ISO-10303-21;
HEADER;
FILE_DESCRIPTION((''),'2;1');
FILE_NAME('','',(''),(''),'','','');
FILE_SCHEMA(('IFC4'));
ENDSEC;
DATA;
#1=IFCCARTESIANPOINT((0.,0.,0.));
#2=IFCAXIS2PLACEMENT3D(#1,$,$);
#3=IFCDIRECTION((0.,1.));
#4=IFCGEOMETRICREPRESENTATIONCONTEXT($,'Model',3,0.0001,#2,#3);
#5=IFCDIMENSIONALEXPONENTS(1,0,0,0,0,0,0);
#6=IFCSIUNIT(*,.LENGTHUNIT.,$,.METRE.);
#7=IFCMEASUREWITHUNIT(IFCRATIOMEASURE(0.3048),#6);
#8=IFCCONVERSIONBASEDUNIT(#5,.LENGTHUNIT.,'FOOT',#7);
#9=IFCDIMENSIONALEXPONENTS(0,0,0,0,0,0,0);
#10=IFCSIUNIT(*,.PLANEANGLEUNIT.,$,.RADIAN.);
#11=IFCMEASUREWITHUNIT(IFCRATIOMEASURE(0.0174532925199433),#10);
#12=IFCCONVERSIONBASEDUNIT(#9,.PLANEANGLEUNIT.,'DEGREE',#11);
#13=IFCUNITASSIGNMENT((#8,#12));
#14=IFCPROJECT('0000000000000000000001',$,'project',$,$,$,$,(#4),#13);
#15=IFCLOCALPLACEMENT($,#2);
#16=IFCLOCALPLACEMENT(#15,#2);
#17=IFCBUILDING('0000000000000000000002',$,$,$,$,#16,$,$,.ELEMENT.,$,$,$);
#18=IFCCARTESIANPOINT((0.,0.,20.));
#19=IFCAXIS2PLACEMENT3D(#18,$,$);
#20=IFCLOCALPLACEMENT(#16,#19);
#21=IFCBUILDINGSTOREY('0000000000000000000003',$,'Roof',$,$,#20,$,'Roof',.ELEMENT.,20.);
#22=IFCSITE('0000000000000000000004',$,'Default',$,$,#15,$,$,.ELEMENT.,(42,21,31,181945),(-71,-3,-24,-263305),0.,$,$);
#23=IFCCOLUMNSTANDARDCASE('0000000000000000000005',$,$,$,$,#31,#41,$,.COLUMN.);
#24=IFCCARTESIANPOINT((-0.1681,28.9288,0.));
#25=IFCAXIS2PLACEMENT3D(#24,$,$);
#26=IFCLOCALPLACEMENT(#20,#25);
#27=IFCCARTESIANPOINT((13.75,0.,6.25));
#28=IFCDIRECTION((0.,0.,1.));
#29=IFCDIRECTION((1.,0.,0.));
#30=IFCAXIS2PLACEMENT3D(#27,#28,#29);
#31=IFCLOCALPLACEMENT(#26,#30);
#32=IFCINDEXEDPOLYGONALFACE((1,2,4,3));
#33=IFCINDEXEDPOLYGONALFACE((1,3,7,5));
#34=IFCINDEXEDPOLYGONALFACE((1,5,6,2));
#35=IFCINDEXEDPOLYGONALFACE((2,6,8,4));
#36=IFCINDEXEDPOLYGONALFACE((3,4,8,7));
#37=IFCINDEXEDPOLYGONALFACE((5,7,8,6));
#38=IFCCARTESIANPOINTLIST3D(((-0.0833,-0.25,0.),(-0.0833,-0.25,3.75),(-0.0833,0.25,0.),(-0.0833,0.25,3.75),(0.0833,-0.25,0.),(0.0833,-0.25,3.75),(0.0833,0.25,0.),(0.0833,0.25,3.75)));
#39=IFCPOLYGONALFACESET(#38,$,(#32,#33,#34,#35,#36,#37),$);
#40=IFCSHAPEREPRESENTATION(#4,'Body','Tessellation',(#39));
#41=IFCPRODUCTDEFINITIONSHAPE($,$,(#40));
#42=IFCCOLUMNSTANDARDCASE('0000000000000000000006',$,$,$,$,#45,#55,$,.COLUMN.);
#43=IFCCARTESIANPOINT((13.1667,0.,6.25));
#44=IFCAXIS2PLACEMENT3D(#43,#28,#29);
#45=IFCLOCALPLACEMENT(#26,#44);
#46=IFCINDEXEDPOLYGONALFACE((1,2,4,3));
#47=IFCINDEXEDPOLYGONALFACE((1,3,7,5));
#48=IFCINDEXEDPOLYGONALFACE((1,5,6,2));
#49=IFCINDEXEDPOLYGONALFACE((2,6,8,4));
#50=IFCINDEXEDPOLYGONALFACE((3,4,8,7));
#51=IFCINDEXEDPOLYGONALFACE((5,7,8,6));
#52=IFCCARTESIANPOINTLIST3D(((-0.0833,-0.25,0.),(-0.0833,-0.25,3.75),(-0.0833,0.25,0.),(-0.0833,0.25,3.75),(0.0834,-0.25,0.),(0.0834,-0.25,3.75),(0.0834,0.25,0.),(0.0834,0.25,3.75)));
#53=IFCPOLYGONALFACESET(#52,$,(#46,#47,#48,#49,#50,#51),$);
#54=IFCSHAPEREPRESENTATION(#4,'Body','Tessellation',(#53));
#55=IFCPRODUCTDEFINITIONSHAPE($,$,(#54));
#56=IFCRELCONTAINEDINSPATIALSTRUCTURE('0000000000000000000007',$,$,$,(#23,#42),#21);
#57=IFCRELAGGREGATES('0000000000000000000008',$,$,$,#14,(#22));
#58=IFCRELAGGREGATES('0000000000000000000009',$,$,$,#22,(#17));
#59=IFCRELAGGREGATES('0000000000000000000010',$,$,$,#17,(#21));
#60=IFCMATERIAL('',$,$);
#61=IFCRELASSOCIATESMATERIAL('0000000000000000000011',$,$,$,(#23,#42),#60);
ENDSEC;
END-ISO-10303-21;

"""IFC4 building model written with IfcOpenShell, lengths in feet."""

from ifc_helpers import new_model, entity, si_unit, converted_unit, direction, frame, origin, place, context, project, spatial, rectangle, extrude, material, element, save


model = new_model("IFC4")

# Units and contexts
model_context = context("Model", 3, precision=0.0001, world=origin(), true_north=direction((0.0, 1.0)))
ifc_project = project(units=[converted_unit("LENGTHUNIT", "FOOT", entity("IfcRatioMeasure", 0.3048), si_unit("LENGTHUNIT", "METRE"), dimensions=[1, 0, 0, 0, 0, 0, 0]), converted_unit("PLANEANGLEUNIT", "DEGREE", entity("IfcRatioMeasure", 0.0174532925199433), si_unit("PLANEANGLEUNIT", "RADIAN"), dimensions=[0, 0, 0, 0, 0, 0, 0])], contexts=[model_context])

# Site, building, storey
site_placement = place(None, origin())
site = spatial("IfcSite", under=ifc_project, at=site_placement, Name="Default", CompositionType="ELEMENT", RefLatitude=(42, 21, 31, 181945), RefLongitude=(-71, -3, -24, -263305), RefElevation=0.0)
building_placement = place(site_placement, origin())
building = spatial("IfcBuilding", under=site, at=building_placement, CompositionType="ELEMENT")
storey_placement = place(building_placement, frame((0.0, 0.0, 20.0)))
storey = spatial("IfcBuildingStorey", under=building, at=storey_placement, Name="Roof", LongName="Roof", CompositionType="ELEMENT", Elevation=20.0)

# Columns
ifc_material_1 = material(Name="")
placement = place(storey_placement, frame((-0.1681, 28.9288, 0.0)))
for number, where, z_axis, x_axis in (
    (1, (13.75, 0.0, 6.25), (0.0, 0.0, 1.0), (1.0, 0.0, 0.0)),
    (2, (13.1667, 0.0, 6.25), (0.0, 0.0, 1.0), (1.0, 0.0, 0.0)),
):
    element("IfcColumnStandardCase", number, at=place(placement, frame(where, z_axis=z_axis, x_axis=x_axis)), inside=storey, material=ifc_material_1, PredefinedType="COLUMN", context=model_context, shape_type="SweptSolid", body=[
        extrude(rectangle(XDim=0.1667, YDim=0.5), origin(), (0.0, 0.0, 1.0), 3.75),
    ])

save(model, "model.ifc")
